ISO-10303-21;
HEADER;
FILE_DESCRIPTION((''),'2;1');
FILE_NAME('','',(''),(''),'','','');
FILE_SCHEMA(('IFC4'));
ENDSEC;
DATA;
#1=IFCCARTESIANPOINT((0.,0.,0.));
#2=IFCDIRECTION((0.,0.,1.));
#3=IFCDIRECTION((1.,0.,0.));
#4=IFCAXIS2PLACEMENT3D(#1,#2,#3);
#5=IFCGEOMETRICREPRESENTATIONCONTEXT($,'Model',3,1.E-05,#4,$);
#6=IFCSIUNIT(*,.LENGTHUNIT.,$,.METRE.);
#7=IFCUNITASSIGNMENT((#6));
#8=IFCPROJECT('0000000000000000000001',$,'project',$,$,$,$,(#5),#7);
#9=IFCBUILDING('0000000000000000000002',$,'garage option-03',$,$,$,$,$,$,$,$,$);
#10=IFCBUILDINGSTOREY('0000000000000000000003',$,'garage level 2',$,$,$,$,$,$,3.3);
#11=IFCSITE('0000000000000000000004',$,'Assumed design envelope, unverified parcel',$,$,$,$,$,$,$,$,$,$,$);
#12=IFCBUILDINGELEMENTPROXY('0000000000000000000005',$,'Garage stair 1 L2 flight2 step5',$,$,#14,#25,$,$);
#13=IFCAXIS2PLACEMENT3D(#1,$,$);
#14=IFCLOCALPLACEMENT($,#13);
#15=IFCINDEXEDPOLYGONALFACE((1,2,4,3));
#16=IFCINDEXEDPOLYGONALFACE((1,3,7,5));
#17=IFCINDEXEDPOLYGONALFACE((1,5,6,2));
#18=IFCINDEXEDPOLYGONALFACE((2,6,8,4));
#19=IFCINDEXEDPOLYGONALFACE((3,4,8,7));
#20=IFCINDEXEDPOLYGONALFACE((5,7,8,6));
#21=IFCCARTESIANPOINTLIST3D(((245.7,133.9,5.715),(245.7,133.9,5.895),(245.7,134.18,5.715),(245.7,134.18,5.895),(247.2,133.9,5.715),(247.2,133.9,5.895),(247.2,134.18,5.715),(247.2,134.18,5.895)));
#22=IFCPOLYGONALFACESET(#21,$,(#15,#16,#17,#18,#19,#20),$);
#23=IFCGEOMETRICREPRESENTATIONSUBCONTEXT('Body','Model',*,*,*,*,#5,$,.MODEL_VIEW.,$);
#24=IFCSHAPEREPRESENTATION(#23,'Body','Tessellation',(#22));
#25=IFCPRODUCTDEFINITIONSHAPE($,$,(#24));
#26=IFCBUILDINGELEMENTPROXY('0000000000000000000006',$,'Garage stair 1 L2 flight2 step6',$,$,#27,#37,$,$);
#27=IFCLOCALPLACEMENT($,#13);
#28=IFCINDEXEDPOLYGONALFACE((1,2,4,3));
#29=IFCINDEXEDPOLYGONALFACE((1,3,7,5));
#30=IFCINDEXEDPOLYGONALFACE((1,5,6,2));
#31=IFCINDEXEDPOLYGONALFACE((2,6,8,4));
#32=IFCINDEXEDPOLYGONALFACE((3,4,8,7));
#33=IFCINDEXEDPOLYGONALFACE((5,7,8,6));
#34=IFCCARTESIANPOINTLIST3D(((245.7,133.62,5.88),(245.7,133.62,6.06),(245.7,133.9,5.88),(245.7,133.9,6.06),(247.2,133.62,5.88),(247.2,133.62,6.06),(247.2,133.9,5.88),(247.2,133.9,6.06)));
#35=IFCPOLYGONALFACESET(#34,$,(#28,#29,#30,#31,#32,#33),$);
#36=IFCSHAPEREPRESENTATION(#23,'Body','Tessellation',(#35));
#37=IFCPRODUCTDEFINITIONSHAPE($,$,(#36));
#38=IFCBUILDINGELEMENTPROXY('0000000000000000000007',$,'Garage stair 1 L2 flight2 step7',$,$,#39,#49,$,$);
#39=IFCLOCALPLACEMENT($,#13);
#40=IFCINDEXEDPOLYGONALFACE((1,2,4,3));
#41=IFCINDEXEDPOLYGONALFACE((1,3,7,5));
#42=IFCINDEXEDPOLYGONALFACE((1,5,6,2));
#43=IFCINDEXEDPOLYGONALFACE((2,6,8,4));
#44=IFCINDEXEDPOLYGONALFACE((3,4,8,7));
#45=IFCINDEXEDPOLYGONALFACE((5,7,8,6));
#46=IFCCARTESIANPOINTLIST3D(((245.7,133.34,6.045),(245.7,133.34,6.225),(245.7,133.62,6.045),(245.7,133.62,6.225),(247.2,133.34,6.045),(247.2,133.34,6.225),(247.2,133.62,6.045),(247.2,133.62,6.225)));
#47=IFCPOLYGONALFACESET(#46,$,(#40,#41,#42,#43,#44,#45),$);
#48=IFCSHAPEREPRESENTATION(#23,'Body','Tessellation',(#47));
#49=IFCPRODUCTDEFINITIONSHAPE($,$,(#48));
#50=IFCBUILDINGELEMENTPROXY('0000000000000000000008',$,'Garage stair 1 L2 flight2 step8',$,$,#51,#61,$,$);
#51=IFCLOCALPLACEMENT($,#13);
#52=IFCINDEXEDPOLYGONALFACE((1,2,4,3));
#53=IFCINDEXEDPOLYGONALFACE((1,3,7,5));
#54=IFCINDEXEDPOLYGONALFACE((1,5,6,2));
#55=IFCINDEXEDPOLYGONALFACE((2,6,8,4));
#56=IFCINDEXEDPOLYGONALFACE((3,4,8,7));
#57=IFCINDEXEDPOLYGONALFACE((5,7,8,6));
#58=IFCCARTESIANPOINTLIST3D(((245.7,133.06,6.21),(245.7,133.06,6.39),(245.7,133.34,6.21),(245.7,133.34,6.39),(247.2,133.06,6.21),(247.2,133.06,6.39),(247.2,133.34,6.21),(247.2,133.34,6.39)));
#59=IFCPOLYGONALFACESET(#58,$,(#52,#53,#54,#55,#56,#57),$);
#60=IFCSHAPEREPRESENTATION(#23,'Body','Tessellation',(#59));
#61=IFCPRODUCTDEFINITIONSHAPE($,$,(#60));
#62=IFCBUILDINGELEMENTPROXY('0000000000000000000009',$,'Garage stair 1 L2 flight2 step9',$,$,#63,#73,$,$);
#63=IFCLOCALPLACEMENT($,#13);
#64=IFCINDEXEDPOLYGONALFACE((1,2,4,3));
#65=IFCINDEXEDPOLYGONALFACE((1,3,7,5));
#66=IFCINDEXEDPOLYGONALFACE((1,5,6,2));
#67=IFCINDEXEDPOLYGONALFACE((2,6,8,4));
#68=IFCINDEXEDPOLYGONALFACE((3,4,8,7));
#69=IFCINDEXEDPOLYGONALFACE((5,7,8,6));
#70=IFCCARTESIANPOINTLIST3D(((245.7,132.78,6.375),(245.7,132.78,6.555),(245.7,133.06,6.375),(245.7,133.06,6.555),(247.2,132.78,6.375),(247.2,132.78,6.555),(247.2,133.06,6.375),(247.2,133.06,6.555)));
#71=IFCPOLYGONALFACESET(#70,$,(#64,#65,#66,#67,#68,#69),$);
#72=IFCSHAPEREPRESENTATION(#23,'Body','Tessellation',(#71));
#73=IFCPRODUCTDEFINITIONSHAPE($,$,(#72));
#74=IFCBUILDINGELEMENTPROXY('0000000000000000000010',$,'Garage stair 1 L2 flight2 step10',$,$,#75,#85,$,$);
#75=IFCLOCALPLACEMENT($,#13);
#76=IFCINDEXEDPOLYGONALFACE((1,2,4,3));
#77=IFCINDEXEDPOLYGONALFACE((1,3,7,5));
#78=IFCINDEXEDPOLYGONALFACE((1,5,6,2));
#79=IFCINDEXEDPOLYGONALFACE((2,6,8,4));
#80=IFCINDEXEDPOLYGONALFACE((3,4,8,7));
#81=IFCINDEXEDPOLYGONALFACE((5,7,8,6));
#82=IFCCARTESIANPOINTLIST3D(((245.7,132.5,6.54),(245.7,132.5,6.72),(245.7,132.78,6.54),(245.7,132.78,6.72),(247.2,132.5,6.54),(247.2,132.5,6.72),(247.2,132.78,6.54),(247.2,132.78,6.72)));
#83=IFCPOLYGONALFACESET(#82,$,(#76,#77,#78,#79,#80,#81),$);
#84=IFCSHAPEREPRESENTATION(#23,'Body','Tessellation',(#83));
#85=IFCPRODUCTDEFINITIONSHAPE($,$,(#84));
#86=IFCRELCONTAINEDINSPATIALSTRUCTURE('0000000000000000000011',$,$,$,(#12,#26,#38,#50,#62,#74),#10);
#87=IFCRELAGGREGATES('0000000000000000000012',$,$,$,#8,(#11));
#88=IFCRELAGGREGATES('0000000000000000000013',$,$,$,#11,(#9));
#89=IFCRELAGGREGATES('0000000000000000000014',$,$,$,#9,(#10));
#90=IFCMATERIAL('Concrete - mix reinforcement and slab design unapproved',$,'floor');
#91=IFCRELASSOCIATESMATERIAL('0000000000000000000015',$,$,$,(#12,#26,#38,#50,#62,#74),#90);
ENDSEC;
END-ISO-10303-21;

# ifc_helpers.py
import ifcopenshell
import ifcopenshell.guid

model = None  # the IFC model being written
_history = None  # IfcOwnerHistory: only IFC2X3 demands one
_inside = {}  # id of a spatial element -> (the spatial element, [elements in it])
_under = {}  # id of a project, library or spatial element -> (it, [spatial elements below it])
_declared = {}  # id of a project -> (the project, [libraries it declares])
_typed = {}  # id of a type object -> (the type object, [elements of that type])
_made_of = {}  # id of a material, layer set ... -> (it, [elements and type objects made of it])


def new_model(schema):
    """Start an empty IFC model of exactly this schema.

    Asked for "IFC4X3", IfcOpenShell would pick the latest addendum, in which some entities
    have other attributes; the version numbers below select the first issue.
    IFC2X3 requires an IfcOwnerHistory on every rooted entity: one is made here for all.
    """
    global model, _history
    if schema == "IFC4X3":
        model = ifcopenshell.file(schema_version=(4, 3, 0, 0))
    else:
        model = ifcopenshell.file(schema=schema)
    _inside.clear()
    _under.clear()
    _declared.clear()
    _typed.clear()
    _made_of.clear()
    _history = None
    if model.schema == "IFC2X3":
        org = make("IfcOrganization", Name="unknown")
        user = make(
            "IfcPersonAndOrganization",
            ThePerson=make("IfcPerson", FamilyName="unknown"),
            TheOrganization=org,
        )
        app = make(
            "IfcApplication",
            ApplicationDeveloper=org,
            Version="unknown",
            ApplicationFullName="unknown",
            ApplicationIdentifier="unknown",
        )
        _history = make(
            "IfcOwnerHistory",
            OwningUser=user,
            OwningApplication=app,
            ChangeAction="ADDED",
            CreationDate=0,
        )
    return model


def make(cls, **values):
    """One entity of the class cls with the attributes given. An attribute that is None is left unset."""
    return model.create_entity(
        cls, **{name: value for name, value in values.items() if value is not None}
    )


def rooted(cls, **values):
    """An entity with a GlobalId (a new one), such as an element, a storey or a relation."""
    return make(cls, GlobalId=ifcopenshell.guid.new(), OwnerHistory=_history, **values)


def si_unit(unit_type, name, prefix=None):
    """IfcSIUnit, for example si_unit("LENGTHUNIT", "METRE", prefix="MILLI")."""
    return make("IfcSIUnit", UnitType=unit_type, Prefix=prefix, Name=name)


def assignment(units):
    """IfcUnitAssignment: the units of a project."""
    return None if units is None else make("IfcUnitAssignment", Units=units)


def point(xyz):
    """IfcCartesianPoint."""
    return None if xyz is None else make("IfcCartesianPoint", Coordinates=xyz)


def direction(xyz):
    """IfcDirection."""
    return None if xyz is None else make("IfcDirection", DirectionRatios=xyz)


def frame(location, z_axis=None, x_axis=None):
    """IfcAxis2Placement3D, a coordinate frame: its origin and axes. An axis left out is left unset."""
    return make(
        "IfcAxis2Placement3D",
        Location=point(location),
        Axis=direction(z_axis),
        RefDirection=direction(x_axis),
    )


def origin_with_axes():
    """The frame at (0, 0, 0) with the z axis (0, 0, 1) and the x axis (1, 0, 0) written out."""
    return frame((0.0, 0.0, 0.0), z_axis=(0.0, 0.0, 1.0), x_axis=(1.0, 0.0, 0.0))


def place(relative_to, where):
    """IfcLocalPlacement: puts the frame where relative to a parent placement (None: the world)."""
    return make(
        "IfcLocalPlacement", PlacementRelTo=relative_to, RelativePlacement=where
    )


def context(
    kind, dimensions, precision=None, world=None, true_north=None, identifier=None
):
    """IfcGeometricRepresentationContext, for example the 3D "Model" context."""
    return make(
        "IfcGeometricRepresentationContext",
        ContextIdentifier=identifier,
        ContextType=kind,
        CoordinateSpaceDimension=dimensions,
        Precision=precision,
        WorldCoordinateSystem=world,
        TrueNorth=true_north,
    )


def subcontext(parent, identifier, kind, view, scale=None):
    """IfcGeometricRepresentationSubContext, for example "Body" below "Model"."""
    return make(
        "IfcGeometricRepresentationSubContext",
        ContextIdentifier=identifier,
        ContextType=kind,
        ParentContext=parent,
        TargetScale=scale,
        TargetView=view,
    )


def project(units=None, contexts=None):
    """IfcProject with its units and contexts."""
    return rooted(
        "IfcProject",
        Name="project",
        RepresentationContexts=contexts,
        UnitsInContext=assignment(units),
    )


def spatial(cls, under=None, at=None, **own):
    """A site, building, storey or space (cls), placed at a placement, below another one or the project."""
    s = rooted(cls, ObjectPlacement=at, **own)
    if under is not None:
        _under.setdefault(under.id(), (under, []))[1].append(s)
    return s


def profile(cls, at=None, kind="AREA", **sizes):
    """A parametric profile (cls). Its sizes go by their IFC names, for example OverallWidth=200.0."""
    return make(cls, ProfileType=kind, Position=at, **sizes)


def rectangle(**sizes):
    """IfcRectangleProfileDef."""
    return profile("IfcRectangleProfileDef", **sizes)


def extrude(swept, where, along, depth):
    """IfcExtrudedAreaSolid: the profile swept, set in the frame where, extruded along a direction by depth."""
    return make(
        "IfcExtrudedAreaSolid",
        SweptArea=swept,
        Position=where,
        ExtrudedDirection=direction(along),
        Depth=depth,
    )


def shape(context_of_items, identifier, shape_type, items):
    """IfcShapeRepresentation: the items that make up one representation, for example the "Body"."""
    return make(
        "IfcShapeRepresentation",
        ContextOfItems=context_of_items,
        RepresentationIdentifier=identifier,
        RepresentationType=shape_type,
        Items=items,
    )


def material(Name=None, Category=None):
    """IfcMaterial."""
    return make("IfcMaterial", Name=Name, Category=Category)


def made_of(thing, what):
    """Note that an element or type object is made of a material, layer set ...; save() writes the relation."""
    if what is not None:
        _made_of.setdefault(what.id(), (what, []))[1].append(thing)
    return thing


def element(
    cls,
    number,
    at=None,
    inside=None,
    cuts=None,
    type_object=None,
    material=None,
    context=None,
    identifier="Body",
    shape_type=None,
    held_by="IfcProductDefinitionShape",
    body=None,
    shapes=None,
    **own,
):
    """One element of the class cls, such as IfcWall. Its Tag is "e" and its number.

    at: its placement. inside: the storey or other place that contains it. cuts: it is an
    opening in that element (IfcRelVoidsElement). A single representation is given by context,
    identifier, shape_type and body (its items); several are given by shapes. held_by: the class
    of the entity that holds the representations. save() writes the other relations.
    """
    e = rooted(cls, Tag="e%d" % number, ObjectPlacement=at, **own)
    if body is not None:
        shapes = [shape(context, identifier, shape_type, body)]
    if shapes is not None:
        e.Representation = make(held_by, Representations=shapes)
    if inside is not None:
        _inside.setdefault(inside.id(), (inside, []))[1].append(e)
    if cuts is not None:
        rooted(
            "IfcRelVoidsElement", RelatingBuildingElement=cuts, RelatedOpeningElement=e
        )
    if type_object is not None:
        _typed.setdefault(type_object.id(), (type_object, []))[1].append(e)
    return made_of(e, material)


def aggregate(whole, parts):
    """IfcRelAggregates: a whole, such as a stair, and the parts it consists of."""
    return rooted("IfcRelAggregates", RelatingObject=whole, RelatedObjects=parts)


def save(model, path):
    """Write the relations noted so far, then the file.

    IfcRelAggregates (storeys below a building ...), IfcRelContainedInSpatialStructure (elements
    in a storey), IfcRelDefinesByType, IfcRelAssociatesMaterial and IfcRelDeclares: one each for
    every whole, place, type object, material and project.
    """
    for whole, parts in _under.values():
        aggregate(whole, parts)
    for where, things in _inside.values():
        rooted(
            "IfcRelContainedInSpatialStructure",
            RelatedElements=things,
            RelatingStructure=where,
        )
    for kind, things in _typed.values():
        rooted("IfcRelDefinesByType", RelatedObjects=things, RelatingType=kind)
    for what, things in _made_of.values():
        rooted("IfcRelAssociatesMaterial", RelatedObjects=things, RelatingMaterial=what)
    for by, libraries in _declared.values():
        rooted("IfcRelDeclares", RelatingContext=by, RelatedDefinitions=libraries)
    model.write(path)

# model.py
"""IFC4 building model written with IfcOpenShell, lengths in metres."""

from ifc_helpers import new_model, si_unit, frame, origin_with_axes, place, context, subcontext, project, spatial, rectangle, extrude, material, element, save


model = new_model("IFC4")

# Units and contexts
model_context = context("Model", 3, precision=1e-05, world=origin_with_axes())
body_context = subcontext(model_context, "Body", "Model", "MODEL_VIEW")
ifc_project = project(units=[si_unit("LENGTHUNIT", "METRE")], contexts=[model_context])

# Site, building, storey
site = spatial("IfcSite", under=ifc_project, Name="Assumed design envelope, unverified parcel")
building = spatial("IfcBuilding", under=site, Name="garage option-03")
storey = spatial("IfcBuildingStorey", under=building, Name="garage level 2", Elevation=3.3)

# Shared definitions
ifc_material_1 = material(Name="Concrete - mix reinforcement and slab design unapproved", Category="floor")

# Building element proxies
for number, where, z_axis, x_axis, name in (
    (1, (246.45, 134.04, 5.715), (0.0, 0.0, 1.0), (1.0, 0.0, 0.0), "Garage stair 1 L2 flight2 step5"),
    (2, (246.45, 133.76, 5.88), (0.0, 0.0, 1.0), (1.0, 0.0, 0.0), "Garage stair 1 L2 flight2 step6"),
    (3, (246.45, 133.48, 6.045), (0.0, 0.0, 1.0), (1.0, 0.0, 0.0), "Garage stair 1 L2 flight2 step7"),
    (4, (246.45, 133.2, 6.21), (0.0, 0.0, 1.0), (1.0, 0.0, 0.0), "Garage stair 1 L2 flight2 step8"),
    (5, (246.45, 132.92, 6.375), (0.0, 0.0, 1.0), (1.0, 0.0, 0.0), "Garage stair 1 L2 flight2 step9"),
    (6, (246.45, 132.64, 6.54), (0.0, 0.0, 1.0), (1.0, 0.0, 0.0), "Garage stair 1 L2 flight2 step10"),
):
    element("IfcBuildingElementProxy", number, at=place(None, frame(where, z_axis=z_axis, x_axis=x_axis)), inside=storey, material=ifc_material_1, Name=name, context=body_context, shape_type="SweptSolid", body=[
        extrude(rectangle(XDim=1.5, YDim=0.28), origin_with_axes(), (0.0, 0.0, 1.0), 0.18),
    ])

save(model, "model.ifc")
